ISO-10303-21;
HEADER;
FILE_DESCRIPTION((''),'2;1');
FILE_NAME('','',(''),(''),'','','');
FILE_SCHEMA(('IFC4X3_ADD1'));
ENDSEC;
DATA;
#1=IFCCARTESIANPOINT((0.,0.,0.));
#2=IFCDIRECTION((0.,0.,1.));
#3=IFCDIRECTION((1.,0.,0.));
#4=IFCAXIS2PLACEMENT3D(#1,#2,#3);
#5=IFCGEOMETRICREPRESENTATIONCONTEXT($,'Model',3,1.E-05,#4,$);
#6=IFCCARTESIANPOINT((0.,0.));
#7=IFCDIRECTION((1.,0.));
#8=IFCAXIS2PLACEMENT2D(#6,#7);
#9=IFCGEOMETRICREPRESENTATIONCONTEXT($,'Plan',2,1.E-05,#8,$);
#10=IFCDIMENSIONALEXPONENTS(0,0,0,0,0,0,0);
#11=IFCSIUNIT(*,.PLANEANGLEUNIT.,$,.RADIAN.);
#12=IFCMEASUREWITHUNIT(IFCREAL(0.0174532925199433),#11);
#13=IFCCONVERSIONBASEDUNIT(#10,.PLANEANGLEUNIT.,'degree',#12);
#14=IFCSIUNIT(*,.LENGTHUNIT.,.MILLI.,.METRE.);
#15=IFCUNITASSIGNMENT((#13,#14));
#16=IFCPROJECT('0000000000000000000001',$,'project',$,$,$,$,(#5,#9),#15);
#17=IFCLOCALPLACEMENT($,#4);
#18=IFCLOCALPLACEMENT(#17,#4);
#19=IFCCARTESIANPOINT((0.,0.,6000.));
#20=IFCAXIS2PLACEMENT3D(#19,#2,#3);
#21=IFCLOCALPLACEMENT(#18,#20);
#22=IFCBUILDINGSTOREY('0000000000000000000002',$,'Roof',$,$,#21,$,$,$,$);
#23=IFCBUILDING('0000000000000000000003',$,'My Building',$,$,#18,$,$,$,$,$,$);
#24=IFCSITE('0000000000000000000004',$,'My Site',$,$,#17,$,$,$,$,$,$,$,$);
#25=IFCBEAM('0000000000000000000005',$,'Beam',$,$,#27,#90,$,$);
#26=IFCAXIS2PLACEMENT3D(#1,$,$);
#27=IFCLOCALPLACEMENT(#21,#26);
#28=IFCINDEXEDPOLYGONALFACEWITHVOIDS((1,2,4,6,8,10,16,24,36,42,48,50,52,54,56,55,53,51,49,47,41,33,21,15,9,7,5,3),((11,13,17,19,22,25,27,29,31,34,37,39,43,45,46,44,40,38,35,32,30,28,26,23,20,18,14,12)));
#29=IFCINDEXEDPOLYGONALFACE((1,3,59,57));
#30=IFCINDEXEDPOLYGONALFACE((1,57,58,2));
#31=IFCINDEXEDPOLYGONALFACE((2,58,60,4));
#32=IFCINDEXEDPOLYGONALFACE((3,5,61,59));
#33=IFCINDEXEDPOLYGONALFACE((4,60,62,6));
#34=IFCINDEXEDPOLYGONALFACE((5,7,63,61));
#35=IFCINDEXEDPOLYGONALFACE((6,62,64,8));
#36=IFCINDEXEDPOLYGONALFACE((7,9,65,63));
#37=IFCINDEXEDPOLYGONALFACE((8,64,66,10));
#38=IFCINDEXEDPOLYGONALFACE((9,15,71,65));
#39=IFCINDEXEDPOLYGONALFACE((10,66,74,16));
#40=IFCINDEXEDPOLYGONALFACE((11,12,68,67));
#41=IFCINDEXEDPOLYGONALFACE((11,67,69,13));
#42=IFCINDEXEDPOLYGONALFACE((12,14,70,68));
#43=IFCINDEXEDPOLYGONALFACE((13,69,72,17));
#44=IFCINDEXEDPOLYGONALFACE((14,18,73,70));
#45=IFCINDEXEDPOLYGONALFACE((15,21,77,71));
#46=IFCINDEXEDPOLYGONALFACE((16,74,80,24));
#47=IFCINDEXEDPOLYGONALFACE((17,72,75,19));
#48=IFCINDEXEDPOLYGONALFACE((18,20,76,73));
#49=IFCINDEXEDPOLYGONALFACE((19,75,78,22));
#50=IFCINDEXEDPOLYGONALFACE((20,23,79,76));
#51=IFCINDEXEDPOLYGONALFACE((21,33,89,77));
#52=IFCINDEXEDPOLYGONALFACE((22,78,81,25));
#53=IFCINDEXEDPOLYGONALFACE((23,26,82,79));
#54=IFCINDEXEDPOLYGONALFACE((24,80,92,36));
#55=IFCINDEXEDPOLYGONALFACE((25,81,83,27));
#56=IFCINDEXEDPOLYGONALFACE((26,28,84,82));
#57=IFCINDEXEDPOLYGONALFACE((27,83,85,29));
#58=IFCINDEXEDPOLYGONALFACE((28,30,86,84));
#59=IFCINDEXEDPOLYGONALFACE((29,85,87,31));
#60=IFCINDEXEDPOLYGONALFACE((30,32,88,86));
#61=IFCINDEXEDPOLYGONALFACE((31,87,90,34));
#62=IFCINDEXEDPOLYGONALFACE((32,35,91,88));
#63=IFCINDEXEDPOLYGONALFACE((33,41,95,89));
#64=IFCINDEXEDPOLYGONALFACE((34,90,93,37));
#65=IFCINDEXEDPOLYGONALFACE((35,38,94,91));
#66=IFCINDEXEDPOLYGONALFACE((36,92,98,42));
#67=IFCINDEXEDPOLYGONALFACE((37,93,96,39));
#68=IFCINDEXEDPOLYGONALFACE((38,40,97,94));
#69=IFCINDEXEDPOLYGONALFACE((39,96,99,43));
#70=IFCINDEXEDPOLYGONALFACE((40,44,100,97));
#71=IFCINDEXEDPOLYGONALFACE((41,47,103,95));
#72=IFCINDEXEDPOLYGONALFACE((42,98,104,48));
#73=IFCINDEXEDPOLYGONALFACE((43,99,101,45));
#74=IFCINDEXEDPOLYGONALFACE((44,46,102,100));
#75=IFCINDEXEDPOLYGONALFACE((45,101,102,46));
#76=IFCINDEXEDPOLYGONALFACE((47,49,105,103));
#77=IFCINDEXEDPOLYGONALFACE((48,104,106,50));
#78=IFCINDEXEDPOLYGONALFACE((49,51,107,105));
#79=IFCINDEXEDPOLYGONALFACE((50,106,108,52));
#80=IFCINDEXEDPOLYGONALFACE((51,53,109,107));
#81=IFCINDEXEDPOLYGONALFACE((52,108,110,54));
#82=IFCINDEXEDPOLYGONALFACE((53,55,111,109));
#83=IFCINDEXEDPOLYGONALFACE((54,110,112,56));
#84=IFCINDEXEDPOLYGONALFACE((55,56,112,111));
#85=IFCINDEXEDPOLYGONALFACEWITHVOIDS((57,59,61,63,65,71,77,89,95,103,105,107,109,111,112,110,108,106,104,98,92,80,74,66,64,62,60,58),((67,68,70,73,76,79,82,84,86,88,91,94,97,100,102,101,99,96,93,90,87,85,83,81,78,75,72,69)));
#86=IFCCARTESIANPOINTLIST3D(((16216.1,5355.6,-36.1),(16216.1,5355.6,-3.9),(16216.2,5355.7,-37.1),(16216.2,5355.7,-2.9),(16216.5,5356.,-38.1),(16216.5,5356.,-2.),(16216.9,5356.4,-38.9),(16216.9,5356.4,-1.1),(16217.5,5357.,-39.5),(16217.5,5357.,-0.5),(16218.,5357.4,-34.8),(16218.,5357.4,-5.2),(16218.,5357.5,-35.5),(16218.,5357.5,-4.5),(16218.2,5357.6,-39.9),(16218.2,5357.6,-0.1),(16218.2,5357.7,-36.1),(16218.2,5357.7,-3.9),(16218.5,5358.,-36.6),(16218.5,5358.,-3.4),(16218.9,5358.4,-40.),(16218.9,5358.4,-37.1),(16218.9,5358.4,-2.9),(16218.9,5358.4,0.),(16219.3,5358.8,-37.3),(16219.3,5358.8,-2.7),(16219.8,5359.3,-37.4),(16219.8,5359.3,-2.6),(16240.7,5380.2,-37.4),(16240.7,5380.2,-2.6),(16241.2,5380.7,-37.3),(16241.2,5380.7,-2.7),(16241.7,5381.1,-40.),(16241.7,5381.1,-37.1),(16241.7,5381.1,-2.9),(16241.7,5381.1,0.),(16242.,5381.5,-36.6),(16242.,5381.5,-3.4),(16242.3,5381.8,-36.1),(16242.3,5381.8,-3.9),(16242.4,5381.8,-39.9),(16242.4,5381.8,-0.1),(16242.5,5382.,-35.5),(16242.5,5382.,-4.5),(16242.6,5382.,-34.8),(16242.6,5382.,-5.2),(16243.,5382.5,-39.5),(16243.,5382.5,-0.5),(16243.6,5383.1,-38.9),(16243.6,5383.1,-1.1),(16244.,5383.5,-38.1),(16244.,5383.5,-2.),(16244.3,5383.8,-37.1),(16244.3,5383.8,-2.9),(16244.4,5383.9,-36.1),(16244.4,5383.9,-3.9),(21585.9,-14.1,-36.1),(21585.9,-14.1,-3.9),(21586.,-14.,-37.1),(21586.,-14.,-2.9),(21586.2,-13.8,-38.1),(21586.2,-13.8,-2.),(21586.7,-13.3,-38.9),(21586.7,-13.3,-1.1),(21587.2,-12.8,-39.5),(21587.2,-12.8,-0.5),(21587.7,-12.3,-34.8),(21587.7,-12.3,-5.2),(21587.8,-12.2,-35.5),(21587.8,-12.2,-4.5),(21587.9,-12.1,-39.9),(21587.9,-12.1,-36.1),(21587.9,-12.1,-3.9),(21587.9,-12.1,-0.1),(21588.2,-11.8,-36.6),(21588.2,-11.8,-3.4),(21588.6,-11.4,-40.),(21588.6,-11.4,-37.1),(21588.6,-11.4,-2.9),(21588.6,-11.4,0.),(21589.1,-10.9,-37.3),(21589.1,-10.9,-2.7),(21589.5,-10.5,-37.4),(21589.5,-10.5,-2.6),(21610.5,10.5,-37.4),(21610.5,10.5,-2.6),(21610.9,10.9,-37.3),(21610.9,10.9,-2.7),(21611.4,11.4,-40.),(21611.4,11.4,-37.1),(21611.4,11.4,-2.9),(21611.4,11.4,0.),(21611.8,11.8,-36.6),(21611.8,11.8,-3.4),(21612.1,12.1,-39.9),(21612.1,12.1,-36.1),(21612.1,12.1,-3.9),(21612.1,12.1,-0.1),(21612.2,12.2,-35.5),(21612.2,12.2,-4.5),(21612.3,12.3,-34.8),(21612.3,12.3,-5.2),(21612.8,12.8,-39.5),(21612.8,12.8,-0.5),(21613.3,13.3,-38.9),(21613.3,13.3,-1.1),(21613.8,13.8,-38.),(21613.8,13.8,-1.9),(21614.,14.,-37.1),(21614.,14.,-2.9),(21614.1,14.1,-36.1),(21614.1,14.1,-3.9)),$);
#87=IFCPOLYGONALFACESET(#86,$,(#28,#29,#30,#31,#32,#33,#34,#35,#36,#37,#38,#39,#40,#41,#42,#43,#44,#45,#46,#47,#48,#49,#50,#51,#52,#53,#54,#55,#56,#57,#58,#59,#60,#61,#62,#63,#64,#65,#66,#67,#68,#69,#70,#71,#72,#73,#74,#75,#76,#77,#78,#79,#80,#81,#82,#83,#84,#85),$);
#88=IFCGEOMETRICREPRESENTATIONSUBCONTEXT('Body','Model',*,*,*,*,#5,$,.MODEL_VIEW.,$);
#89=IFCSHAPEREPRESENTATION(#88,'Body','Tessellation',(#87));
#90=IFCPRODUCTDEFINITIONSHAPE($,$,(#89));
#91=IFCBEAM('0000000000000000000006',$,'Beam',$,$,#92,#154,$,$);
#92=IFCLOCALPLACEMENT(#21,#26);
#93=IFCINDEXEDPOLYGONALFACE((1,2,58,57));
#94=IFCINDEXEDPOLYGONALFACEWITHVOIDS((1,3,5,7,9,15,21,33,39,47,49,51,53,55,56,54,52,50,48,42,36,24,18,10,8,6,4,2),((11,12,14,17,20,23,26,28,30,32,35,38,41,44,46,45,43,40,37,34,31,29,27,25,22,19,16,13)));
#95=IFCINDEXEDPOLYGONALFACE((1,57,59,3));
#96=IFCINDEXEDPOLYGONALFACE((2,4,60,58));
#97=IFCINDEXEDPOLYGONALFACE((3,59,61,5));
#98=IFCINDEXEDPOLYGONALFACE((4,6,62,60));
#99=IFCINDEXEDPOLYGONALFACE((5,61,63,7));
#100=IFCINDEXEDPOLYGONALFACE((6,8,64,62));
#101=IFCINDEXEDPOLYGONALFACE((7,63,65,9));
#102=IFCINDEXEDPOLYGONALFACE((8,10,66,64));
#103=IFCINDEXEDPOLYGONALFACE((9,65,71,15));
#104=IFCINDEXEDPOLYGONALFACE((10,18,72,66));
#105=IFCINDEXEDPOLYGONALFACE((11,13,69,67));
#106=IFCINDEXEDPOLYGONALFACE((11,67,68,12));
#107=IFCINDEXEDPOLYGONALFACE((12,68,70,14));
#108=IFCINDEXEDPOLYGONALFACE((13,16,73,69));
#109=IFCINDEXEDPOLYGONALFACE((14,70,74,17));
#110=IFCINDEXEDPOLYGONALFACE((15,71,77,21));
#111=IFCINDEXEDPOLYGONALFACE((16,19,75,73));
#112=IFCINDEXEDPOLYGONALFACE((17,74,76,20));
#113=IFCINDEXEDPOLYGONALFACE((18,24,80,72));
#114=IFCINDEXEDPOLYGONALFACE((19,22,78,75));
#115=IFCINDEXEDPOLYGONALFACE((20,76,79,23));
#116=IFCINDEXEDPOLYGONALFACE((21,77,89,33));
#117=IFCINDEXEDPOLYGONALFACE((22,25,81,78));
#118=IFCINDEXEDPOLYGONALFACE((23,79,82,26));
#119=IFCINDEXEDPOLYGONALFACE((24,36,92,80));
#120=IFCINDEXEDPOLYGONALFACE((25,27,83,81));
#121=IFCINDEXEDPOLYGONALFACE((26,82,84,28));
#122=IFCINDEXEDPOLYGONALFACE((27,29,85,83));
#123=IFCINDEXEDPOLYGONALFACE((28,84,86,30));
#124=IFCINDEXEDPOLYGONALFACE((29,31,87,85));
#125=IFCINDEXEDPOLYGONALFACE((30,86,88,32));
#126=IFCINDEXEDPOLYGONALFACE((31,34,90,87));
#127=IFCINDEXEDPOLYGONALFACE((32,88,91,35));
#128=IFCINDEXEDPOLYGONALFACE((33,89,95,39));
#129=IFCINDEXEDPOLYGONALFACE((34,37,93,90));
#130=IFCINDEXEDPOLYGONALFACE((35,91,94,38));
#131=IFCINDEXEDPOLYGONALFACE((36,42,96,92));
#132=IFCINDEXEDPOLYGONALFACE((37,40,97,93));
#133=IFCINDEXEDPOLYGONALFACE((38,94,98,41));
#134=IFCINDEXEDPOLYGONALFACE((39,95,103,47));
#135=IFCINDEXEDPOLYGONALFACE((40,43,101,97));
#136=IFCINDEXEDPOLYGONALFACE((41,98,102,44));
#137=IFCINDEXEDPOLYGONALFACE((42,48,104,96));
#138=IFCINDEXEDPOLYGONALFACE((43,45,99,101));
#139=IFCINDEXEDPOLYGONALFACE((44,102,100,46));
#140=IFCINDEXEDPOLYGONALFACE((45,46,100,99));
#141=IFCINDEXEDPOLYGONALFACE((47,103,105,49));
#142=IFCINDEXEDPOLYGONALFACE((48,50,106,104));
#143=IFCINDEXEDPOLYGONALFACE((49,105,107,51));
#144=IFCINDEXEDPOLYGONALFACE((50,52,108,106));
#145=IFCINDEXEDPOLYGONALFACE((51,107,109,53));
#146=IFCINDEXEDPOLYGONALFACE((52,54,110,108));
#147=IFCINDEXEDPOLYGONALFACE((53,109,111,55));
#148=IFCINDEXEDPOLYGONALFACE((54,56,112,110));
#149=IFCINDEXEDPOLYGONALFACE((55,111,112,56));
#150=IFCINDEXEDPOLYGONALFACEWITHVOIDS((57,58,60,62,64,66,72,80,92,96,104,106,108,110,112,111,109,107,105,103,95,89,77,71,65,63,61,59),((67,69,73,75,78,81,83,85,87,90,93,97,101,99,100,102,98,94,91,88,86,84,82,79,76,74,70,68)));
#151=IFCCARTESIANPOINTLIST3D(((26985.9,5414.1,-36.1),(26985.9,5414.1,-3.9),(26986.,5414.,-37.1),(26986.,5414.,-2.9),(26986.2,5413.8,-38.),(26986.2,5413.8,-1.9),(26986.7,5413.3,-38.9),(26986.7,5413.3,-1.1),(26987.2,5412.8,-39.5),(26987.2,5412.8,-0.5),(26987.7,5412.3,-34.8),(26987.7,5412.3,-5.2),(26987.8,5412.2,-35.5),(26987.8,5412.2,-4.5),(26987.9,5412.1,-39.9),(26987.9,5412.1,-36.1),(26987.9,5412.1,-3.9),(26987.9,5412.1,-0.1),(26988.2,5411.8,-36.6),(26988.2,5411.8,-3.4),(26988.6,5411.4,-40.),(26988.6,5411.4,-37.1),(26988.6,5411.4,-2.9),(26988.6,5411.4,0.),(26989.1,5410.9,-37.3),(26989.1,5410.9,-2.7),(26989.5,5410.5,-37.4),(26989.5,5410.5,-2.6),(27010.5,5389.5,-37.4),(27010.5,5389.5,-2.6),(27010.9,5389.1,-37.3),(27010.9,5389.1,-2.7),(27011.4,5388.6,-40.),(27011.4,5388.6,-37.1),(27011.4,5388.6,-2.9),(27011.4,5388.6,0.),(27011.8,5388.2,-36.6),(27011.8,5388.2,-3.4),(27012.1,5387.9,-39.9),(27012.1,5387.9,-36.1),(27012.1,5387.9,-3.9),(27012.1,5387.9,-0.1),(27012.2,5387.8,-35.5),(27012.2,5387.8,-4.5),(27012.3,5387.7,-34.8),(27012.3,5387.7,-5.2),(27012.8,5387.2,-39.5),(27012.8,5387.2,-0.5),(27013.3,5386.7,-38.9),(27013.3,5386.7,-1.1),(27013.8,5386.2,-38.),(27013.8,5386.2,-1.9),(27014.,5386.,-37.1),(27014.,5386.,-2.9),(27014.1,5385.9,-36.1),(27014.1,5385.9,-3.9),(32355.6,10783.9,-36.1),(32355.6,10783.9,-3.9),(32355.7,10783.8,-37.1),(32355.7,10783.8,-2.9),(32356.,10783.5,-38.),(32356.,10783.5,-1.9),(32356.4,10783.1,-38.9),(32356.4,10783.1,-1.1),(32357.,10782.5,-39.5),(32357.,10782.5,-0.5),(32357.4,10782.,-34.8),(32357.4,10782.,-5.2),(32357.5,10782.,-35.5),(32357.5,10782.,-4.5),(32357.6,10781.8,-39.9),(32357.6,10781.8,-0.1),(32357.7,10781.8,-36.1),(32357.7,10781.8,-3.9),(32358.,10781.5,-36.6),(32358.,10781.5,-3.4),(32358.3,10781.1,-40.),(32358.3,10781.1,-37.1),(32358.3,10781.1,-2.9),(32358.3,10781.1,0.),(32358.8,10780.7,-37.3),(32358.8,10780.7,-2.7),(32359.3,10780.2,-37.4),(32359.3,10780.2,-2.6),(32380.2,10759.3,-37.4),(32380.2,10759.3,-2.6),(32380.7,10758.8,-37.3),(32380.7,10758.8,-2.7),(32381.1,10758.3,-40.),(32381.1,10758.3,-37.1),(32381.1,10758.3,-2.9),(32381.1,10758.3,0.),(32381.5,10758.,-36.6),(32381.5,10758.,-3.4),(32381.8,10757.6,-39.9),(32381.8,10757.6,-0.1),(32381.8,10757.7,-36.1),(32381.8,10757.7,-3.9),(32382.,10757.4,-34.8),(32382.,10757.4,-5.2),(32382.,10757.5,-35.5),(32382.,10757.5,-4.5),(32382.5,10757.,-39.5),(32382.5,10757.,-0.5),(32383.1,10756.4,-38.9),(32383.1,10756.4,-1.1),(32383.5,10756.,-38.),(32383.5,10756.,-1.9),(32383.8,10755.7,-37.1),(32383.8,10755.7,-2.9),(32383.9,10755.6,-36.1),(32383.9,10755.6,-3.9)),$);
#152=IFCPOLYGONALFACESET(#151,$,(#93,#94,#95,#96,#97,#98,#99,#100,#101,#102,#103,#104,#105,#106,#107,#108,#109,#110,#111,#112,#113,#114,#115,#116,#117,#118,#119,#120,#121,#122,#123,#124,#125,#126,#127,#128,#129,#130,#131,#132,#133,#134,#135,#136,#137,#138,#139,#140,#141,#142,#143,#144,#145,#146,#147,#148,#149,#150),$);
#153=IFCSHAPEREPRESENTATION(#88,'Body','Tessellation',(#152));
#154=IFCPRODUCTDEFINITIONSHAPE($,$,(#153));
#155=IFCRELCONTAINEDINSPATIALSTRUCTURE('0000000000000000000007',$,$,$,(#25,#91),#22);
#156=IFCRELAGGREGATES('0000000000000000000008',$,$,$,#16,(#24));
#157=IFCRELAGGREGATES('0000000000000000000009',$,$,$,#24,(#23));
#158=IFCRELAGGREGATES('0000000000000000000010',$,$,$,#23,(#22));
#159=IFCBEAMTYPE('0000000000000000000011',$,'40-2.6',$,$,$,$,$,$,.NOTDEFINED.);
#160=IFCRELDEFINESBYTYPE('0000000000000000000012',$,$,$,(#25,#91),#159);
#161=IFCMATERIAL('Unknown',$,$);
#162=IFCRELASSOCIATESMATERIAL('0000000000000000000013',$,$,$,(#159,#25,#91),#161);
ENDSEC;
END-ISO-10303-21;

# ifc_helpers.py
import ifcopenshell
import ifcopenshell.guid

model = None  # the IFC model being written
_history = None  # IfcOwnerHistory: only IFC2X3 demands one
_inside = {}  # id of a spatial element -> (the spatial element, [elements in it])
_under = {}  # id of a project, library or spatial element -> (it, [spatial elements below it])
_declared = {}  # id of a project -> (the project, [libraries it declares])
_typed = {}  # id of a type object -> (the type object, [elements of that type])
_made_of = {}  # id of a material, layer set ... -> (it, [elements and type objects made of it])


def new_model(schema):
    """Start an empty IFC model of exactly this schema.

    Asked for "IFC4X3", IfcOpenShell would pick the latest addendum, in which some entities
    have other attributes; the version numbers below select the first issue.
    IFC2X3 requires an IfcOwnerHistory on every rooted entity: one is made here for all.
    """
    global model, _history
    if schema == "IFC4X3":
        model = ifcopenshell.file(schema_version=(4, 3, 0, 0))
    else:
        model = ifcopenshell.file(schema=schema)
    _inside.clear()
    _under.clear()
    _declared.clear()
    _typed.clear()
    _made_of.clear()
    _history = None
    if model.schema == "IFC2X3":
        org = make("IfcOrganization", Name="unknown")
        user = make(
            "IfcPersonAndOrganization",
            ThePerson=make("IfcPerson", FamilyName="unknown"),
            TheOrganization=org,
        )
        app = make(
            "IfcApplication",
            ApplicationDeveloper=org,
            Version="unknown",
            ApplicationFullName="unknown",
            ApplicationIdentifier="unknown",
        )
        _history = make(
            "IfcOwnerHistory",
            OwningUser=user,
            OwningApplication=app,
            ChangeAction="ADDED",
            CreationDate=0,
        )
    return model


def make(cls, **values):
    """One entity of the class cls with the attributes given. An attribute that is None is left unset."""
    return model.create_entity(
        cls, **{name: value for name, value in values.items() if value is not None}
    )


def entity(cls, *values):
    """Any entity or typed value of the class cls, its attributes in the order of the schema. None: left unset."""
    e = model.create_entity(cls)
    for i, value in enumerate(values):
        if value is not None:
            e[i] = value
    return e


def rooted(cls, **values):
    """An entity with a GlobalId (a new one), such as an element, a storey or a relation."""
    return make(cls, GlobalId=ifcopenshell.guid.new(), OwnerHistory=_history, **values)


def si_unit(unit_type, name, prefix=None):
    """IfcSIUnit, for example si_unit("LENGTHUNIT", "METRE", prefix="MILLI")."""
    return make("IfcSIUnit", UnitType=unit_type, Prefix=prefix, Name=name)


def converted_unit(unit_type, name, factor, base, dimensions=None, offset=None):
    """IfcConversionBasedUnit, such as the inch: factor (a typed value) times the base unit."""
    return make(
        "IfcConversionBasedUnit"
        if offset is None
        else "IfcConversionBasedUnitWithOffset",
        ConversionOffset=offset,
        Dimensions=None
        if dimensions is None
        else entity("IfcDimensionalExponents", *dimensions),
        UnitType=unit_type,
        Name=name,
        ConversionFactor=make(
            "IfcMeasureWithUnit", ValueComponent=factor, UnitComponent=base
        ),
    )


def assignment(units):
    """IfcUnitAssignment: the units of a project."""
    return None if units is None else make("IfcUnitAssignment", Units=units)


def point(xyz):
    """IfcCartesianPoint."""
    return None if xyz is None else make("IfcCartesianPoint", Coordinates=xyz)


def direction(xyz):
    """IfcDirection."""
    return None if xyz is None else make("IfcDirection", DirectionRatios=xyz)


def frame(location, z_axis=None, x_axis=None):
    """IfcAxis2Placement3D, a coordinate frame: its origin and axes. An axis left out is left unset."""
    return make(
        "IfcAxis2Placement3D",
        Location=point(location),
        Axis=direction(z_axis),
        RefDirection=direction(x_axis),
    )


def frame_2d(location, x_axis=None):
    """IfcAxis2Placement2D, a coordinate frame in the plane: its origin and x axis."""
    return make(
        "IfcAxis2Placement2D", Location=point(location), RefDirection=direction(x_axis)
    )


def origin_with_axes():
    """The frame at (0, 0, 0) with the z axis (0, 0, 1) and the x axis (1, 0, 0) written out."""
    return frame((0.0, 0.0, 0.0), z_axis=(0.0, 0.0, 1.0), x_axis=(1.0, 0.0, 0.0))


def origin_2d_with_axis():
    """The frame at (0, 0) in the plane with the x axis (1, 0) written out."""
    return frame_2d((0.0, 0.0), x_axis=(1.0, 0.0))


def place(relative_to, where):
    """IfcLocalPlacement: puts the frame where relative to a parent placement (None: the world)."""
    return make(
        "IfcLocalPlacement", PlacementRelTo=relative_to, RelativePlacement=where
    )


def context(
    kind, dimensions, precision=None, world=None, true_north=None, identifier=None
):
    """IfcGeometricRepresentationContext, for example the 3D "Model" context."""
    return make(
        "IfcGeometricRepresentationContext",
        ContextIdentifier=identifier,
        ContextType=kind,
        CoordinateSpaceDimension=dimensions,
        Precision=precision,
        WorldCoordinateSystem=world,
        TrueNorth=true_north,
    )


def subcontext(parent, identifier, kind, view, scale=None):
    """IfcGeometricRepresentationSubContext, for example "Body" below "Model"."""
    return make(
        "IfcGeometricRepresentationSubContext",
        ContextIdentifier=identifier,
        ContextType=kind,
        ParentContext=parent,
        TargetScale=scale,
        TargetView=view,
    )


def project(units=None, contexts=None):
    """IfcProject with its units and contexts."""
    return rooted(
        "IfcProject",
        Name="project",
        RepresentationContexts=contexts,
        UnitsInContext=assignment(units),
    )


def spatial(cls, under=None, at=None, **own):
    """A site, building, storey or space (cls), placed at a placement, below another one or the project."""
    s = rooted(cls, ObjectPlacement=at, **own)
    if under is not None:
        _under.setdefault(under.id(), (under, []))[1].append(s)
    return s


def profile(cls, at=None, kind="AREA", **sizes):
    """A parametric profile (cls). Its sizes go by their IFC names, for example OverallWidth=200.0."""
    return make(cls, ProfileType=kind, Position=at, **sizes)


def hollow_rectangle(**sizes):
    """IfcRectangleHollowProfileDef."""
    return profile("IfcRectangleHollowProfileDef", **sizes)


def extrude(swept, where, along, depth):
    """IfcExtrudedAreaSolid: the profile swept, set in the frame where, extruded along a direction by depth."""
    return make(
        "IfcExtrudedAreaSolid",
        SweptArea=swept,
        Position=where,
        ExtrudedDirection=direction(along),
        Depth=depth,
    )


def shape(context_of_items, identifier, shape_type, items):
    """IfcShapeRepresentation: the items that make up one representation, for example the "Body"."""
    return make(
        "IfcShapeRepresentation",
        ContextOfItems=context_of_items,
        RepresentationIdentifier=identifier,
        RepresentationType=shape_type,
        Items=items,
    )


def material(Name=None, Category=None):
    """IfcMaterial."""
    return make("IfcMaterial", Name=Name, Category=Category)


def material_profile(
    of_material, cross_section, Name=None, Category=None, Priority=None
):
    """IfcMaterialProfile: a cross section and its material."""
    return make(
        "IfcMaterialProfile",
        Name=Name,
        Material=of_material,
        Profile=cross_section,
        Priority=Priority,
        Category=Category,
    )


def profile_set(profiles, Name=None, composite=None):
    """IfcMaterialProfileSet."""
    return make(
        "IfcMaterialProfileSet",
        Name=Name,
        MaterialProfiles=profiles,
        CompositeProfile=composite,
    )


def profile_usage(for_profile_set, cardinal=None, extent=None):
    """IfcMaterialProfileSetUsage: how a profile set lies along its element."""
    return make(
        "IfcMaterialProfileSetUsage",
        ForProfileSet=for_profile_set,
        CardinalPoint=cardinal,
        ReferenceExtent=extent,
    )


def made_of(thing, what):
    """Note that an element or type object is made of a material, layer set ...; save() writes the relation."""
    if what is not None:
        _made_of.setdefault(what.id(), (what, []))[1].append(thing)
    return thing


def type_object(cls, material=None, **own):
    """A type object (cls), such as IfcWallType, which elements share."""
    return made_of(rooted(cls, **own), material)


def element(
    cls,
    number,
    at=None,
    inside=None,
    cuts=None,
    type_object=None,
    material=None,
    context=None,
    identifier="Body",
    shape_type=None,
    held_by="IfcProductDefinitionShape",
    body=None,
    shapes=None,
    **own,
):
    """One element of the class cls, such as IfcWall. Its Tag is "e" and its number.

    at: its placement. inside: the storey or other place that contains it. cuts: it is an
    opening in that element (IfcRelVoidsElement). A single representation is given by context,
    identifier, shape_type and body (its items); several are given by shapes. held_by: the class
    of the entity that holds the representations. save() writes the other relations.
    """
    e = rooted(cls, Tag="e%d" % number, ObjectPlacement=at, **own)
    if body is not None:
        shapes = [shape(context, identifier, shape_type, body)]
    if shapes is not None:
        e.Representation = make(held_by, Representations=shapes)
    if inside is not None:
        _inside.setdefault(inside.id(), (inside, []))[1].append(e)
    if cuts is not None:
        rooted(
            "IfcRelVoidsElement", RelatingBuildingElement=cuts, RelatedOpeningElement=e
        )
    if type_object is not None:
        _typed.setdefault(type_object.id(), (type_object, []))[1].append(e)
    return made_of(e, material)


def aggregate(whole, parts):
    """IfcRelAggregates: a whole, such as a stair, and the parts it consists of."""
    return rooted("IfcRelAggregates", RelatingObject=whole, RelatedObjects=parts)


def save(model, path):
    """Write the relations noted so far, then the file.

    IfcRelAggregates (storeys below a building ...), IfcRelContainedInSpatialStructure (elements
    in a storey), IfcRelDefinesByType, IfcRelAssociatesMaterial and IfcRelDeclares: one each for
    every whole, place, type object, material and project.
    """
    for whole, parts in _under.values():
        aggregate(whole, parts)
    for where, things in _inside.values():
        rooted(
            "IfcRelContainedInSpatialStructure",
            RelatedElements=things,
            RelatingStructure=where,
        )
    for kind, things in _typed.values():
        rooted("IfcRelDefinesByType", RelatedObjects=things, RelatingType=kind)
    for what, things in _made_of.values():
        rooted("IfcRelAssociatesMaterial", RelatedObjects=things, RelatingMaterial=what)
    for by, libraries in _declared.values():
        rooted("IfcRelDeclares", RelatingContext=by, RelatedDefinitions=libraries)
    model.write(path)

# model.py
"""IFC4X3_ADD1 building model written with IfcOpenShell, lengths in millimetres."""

from ifc_helpers import new_model, entity, si_unit, converted_unit, frame, origin_with_axes, origin_2d_with_axis, place, context, subcontext, project, spatial, hollow_rectangle, extrude, material, material_profile, profile_set, profile_usage, type_object, element, save


model = new_model("IFC4X3_ADD1")

# Units and contexts
model_context = context("Model", 3, precision=1e-05, world=origin_with_axes())
plan_context = context("Plan", 2, precision=1e-05, world=origin_2d_with_axis())
body_context = subcontext(model_context, "Body", "Model", "MODEL_VIEW")
ifc_project = project(units=[converted_unit("PLANEANGLEUNIT", "degree", entity("IfcReal", 0.0174532925199433), si_unit("PLANEANGLEUNIT", "RADIAN"), dimensions=[0, 0, 0, 0, 0, 0, 0]), si_unit("LENGTHUNIT", "METRE", prefix="MILLI")], contexts=[model_context, plan_context])

# Site, building, storey
site_placement = place(None, origin_with_axes())
site = spatial("IfcSite", under=ifc_project, at=site_placement, Name="My Site")
building_placement = place(site_placement, origin_with_axes())
building = spatial("IfcBuilding", under=site, at=building_placement, Name="My Building")
storey_placement = place(building_placement, frame((0.0, 0.0, 6000.0), z_axis=(0.0, 0.0, 1.0), x_axis=(1.0, 0.0, 0.0)))
storey = spatial("IfcBuildingStorey", under=building, at=storey_placement, Name="Roof")

# Beams
ifc_material = material(Name="Unknown")
ifc_material_profile_1 = material_profile(ifc_material, hollow_rectangle(XDim=40.0, YDim=40.0, WallThickness=2.6, InnerFilletRadius=2.6, OuterFilletRadius=3.9))
ifc_profile_set_1 = profile_set([ifc_material_profile_1])
ifc_profile_usage_1 = profile_usage(ifc_profile_set_1, cardinal=8)
beam_type_1 = type_object("IfcBeamType", Name="40-2.6", PredefinedType="NOTDEFINED", material=ifc_profile_set_1)
beam_1_placement = place(storey_placement, frame((21600.0, 0.0, 0.0), z_axis=(-0.707107, 0.707107, 0.0), x_axis=(-0.707107, -0.707107, 0.0)))
element("IfcBeam", 1, at=beam_1_placement, inside=storey, type_object=beam_type_1, material=ifc_profile_usage_1, Name="Beam", context=body_context, shape_type="SweptSolid", body=[
    extrude(hollow_rectangle(XDim=40.0, YDim=40.0, WallThickness=2.6, InnerFilletRadius=2.6, OuterFilletRadius=3.9), frame((0.0, -20.0, 0.0), z_axis=(0.0, 0.0, 1.0), x_axis=(1.0, 0.0, 0.0)), (0.0, 0.0, 1.0), 7594.0),
])
ifc_profile_usage_2 = profile_usage(ifc_profile_set_1, cardinal=8)
beam_2_placement = place(storey_placement, frame((27000.0, 5400.0, 0.0), z_axis=(0.707107, 0.707107, 0.0), x_axis=(-0.707107, 0.707107, 0.0)))
element("IfcBeam", 2, at=beam_2_placement, inside=storey, type_object=beam_type_1, material=ifc_profile_usage_2, Name="Beam", context=body_context, shape_type="SweptSolid", body=[
    extrude(hollow_rectangle(XDim=40.0, YDim=40.0, WallThickness=2.6, InnerFilletRadius=2.6, OuterFilletRadius=3.9), frame((0.0, -20.0, 0.0), z_axis=(0.0, 0.0, 1.0), x_axis=(1.0, 0.0, 0.0)), (0.0, 0.0, 1.0), 7594.0),
])

save(model, "model.ifc")
